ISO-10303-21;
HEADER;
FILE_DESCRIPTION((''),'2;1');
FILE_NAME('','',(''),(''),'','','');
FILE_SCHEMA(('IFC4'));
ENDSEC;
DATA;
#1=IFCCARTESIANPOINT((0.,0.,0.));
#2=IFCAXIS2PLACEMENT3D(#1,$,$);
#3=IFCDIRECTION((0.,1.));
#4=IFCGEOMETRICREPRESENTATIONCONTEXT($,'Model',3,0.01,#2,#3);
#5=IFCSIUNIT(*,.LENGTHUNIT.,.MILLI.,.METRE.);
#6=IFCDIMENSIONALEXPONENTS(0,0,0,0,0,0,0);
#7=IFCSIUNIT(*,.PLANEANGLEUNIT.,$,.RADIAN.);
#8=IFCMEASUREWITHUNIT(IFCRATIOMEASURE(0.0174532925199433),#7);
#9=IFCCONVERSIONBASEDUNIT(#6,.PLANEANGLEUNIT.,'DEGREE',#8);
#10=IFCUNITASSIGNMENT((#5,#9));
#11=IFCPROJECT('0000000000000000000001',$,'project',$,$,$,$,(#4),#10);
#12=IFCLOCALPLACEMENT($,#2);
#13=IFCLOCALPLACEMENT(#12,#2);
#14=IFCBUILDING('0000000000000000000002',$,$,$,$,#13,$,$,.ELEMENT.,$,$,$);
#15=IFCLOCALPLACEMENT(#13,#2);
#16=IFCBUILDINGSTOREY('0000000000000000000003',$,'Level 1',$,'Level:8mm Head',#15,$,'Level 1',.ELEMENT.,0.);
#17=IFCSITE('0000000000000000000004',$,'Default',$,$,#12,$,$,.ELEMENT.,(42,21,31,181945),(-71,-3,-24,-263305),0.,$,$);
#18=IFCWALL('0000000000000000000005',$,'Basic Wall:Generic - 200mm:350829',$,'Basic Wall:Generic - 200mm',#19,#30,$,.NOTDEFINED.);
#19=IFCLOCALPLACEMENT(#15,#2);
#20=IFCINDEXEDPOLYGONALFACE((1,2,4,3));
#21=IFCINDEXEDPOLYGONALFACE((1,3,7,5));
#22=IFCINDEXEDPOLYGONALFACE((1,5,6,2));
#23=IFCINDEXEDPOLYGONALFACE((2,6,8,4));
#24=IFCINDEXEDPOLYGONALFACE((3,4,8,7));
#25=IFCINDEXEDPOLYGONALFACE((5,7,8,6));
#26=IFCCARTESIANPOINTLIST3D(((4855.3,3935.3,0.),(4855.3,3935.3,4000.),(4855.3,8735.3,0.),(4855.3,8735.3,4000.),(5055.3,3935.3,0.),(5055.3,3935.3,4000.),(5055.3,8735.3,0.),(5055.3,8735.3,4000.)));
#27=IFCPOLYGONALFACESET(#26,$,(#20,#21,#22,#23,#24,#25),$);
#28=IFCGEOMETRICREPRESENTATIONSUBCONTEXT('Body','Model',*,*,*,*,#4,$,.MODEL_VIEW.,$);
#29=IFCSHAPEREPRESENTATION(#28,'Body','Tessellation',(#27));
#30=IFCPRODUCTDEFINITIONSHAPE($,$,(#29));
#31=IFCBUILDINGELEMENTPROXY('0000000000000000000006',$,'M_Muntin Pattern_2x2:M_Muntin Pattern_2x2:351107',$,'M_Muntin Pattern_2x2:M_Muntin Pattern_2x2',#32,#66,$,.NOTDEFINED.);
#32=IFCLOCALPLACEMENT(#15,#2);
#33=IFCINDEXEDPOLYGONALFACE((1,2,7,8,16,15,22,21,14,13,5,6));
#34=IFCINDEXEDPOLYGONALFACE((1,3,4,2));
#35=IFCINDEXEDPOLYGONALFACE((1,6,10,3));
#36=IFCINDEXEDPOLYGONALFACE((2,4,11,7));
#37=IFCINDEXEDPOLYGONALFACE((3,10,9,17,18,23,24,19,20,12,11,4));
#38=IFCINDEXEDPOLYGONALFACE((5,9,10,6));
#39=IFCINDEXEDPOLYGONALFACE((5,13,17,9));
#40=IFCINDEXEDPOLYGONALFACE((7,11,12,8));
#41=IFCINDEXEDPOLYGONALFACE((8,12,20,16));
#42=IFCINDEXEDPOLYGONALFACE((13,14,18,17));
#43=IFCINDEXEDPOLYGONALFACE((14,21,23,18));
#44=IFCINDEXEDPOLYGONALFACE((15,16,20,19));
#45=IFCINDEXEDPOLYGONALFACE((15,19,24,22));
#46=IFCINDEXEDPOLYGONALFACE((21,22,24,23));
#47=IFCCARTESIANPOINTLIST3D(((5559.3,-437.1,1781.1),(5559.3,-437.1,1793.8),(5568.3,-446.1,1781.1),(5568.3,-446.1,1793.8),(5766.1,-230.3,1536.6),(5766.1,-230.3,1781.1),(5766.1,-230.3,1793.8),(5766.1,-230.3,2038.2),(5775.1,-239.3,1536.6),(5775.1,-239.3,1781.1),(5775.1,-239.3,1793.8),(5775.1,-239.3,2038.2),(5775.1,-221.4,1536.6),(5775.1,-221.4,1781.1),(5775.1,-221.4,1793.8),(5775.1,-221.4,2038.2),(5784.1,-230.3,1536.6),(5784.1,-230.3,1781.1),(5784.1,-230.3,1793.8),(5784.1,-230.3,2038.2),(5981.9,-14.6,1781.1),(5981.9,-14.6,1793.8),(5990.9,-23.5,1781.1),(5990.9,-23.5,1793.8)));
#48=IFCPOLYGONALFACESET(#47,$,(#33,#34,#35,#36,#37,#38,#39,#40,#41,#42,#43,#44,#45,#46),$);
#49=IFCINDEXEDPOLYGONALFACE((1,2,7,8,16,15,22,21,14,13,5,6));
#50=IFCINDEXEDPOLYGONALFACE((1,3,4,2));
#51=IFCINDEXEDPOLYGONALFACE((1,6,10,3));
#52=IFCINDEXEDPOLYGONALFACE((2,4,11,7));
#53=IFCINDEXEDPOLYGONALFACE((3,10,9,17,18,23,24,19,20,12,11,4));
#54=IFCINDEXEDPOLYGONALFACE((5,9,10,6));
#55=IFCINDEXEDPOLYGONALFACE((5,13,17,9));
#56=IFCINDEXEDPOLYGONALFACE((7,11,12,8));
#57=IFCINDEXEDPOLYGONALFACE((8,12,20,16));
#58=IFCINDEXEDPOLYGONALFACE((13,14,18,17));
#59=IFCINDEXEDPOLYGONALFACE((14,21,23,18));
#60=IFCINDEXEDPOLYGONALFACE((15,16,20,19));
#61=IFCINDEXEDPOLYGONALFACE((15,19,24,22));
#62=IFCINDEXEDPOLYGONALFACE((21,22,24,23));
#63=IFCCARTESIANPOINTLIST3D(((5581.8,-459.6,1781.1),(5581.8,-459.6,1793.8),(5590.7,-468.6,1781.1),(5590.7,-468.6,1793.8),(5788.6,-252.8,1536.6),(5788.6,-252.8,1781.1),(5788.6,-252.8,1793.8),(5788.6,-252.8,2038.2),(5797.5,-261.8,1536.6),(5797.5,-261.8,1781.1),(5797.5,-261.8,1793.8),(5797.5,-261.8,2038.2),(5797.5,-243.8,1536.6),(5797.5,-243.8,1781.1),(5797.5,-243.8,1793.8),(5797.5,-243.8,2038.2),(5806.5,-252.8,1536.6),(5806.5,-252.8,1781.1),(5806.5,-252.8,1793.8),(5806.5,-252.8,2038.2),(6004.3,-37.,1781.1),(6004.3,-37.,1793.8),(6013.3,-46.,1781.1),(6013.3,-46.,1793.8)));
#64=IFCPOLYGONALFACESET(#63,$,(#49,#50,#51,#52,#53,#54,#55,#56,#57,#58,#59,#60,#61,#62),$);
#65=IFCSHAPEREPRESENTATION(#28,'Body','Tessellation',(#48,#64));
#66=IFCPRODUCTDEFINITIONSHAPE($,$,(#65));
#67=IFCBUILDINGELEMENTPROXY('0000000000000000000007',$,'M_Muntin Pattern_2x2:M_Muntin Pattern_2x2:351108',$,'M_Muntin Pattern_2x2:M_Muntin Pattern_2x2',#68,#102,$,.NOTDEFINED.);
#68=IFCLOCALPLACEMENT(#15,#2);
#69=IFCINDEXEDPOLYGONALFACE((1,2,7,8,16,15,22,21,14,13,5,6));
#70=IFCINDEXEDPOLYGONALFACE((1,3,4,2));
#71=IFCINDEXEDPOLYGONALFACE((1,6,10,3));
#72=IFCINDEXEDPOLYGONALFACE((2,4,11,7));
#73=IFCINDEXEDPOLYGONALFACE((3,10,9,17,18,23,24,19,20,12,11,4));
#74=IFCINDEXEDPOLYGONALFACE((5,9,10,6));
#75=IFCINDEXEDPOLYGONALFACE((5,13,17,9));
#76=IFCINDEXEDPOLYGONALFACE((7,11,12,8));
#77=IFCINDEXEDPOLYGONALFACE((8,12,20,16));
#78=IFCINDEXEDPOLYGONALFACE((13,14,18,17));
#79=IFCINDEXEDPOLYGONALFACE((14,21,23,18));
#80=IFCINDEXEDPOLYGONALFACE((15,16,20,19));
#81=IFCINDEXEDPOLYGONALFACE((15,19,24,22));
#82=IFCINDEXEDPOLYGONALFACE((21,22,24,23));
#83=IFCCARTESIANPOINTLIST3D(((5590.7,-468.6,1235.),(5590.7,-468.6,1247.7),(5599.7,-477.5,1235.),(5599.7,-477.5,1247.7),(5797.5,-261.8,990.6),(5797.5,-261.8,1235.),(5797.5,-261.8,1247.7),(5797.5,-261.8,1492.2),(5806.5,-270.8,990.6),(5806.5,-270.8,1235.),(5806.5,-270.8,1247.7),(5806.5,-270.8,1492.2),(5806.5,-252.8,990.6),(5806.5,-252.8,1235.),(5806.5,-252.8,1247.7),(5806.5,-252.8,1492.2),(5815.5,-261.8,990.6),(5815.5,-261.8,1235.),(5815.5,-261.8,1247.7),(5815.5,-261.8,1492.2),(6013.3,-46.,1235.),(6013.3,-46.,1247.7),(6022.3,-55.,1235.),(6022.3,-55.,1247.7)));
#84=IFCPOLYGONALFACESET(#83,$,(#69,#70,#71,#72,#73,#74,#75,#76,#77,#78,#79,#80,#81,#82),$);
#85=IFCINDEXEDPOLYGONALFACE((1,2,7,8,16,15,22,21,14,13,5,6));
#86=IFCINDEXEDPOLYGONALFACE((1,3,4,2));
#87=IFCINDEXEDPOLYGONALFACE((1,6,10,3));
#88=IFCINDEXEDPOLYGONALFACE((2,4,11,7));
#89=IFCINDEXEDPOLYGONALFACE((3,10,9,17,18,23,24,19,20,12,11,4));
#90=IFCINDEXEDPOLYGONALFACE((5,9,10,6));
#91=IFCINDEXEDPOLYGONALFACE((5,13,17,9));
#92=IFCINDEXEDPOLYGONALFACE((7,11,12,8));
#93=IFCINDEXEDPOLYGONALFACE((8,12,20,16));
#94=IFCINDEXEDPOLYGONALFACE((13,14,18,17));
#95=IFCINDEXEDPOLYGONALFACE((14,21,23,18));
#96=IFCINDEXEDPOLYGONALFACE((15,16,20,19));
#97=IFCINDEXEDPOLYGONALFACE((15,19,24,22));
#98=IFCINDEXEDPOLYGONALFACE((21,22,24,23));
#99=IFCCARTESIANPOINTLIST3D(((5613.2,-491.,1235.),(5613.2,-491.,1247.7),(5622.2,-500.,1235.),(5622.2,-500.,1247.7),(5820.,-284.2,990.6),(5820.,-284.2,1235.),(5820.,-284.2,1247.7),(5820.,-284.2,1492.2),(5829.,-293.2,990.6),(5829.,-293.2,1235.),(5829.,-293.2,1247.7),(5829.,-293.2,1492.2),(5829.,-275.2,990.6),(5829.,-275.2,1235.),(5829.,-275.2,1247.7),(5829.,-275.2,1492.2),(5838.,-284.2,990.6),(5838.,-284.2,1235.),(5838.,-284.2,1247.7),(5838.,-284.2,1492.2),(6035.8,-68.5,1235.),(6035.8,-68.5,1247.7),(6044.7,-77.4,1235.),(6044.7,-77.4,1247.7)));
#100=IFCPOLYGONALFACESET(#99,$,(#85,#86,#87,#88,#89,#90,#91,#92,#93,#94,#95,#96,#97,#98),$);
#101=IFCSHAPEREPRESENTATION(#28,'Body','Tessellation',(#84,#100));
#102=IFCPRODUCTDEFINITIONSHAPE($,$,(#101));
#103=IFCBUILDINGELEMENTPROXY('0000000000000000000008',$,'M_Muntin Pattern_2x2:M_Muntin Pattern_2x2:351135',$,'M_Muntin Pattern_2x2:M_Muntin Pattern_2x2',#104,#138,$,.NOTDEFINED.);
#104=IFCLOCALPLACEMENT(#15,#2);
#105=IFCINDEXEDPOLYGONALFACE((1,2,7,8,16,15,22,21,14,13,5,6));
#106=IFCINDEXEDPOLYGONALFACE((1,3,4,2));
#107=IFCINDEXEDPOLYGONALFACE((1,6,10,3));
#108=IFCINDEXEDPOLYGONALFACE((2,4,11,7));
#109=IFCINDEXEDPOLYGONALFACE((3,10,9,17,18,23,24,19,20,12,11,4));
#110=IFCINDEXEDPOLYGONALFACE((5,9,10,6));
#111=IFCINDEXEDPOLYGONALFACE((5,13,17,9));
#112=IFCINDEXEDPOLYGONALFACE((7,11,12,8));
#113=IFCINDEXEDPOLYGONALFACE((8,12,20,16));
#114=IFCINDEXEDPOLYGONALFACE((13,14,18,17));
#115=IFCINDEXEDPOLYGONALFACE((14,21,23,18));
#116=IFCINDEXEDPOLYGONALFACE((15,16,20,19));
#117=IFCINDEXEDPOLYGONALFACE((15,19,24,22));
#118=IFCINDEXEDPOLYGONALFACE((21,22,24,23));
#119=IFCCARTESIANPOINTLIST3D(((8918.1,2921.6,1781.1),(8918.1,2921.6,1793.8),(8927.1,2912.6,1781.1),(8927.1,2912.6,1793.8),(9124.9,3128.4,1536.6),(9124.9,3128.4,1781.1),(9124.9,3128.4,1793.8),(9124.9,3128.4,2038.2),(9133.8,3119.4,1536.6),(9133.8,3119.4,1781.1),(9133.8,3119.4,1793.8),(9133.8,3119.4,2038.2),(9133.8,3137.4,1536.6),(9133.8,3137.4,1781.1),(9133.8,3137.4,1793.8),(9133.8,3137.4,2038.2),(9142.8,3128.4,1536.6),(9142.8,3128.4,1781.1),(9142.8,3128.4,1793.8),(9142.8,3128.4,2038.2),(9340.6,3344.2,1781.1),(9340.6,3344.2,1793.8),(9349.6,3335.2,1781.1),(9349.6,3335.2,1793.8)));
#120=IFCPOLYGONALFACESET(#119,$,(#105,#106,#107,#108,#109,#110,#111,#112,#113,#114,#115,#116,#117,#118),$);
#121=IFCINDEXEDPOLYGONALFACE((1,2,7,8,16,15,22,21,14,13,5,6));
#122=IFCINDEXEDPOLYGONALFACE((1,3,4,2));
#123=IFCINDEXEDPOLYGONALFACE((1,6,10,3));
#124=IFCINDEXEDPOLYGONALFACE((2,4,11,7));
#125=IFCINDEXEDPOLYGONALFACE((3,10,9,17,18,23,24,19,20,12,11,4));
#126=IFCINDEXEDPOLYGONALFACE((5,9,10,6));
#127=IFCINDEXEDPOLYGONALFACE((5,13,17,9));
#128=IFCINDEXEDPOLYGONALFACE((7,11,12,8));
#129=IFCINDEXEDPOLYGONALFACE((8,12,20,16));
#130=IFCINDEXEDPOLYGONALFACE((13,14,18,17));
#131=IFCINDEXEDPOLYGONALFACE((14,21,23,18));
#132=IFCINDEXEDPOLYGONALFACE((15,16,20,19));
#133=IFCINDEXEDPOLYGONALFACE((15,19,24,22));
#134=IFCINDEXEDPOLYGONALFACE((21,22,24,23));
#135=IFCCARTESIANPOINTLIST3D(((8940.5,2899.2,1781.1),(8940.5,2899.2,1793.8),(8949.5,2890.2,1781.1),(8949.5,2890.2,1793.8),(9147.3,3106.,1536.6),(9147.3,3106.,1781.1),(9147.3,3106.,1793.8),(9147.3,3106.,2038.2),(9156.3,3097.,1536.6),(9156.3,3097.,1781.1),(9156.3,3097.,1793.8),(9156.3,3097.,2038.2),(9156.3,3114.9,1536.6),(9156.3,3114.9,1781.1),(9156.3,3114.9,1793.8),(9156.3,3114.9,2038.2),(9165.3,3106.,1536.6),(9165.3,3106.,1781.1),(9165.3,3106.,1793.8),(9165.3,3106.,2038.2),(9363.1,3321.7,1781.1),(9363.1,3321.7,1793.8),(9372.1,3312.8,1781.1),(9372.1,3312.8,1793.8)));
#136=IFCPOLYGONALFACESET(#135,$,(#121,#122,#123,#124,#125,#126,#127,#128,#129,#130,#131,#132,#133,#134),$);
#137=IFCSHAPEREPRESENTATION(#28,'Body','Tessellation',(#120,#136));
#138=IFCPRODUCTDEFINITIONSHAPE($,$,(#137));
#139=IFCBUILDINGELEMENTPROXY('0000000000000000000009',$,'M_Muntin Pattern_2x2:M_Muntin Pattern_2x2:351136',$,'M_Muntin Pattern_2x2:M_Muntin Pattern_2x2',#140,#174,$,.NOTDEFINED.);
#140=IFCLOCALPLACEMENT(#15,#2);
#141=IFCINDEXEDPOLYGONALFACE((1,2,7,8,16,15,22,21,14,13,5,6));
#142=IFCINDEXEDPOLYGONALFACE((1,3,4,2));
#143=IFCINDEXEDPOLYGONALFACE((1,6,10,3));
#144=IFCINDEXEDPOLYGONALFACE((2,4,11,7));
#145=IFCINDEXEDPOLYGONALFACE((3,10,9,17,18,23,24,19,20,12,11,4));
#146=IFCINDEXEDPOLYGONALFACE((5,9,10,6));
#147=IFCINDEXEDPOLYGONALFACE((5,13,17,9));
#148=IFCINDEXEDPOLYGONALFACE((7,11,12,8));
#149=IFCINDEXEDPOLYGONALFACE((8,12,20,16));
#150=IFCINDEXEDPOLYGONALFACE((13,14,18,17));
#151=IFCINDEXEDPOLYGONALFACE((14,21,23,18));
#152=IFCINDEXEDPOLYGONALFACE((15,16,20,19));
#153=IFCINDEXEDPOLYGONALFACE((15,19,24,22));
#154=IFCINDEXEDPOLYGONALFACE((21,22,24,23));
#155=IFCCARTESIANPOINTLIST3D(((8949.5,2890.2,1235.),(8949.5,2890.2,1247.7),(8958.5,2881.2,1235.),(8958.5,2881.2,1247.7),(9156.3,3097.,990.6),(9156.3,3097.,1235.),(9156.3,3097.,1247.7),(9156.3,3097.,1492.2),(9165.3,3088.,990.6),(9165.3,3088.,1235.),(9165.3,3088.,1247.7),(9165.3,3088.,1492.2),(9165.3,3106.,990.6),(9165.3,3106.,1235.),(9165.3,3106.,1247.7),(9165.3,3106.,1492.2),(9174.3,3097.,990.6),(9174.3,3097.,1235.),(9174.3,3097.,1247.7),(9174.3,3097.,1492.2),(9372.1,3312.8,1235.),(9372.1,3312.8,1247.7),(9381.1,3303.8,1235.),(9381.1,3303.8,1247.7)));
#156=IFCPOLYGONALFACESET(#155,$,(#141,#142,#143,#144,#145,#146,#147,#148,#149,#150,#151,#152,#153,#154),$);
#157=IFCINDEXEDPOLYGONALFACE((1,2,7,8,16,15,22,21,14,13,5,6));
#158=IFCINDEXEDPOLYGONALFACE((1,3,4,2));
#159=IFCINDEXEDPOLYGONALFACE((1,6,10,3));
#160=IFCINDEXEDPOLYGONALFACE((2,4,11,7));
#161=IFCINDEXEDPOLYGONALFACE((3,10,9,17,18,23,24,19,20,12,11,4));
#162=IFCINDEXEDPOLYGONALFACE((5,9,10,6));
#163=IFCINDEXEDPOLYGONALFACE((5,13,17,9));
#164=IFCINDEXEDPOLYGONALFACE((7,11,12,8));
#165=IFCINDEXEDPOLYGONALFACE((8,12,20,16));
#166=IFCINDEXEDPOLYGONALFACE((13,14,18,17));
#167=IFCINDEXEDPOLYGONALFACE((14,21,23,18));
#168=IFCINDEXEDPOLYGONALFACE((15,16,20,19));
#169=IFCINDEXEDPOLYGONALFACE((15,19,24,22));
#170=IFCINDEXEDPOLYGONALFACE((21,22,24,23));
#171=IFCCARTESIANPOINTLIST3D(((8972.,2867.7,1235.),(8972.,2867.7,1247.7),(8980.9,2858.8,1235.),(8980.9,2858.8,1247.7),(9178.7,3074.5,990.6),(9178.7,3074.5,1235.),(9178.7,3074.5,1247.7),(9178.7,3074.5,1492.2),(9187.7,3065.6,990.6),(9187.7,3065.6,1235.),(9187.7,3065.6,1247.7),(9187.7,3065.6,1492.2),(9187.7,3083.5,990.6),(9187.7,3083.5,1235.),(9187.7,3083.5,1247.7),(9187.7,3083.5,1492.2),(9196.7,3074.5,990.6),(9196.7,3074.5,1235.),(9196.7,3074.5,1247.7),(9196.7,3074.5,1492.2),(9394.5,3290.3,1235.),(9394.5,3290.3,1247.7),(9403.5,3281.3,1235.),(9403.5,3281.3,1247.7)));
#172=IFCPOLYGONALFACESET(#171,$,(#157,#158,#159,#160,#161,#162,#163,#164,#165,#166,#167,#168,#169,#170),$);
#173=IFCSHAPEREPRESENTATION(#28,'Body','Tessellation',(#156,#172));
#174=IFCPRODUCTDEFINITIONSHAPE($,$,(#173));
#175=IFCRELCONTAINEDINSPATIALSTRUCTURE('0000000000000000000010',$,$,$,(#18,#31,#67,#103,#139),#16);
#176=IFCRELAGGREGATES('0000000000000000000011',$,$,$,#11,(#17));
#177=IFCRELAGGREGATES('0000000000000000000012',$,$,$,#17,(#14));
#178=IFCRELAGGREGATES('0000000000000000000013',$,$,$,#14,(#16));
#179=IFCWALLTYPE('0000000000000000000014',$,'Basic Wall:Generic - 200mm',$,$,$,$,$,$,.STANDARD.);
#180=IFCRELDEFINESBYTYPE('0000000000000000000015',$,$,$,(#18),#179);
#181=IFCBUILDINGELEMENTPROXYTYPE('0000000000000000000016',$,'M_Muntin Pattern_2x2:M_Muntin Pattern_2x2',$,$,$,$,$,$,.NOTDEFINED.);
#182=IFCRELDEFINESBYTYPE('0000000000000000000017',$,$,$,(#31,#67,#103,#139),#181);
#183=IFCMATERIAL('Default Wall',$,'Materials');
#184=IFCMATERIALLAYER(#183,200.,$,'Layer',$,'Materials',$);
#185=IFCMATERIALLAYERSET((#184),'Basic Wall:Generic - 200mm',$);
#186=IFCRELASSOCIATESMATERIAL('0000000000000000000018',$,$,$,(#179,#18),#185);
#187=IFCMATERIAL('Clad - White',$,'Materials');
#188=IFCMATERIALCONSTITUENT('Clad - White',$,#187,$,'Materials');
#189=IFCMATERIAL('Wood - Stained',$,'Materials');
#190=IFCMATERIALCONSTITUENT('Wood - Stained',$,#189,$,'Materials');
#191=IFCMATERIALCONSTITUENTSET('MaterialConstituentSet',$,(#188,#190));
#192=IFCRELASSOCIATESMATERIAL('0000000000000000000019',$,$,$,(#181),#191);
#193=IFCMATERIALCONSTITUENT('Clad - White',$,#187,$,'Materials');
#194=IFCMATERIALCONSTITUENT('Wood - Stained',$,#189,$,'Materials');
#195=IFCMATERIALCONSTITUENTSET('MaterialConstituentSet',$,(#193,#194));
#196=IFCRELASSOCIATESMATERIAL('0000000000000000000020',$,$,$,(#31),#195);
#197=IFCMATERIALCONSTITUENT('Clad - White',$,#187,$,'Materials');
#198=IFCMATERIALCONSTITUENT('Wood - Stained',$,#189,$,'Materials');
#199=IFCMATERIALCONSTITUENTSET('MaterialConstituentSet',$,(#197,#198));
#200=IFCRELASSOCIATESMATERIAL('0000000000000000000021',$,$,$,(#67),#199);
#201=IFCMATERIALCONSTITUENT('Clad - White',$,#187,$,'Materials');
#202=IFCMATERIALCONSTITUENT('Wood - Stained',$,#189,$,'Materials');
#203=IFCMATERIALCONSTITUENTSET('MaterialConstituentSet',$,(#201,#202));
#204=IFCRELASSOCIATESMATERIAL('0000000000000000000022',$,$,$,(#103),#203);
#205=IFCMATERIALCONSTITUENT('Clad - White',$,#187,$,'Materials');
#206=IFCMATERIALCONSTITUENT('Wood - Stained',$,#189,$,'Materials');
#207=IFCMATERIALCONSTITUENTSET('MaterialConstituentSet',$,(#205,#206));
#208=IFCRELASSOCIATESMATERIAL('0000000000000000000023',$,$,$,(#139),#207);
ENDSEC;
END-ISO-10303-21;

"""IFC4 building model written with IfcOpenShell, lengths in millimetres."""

from ifc_helpers import new_model, entity, si_unit, converted_unit, direction, frame, frame_2d, origin, place, context, subcontext, project, spatial, polyline, rectangle, outline, extrude, source, transform, mapped, material, layer, layer_set, layer_usage, constituent, constituent_set, type_object, type_shapes, element, save


model = new_model("IFC4")

# Units and contexts
model_context = context("Model", 3, precision=0.01, world=origin(), true_north=direction((0.0, 1.0)))
body_context = subcontext(model_context, "Body", "Model", "MODEL_VIEW")
ifc_project = project(units=[si_unit("LENGTHUNIT", "METRE", prefix="MILLI"), converted_unit("PLANEANGLEUNIT", "DEGREE", entity("IfcRatioMeasure", 0.0174532925199433), si_unit("PLANEANGLEUNIT", "RADIAN"), dimensions=[0, 0, 0, 0, 0, 0, 0])], contexts=[model_context])

# Site, building, storey
site_placement = place(None, origin())
site = spatial("IfcSite", under=ifc_project, at=site_placement, Name="Default", CompositionType="ELEMENT", RefLatitude=(42, 21, 31, 181945), RefLongitude=(-71, -3, -24, -263305), RefElevation=0.0)
building_placement = place(site_placement, origin())
building = spatial("IfcBuilding", under=site, at=building_placement, CompositionType="ELEMENT")
storey_placement = place(building_placement, origin())
storey = spatial("IfcBuildingStorey", under=building, at=storey_placement, Name="Level 1", ObjectType="Level:8mm Head", LongName="Level 1", CompositionType="ELEMENT", Elevation=0.0)

# Shared definitions
ifc_material_1 = material(Name="Default Wall", Category="Materials")
ifc_layer = layer(ifc_material_1, 200.0, Name="Layer", Category="Materials")
ifc_layer_set = layer_set([ifc_layer], Name="Basic Wall:Generic - 200mm")
wall_type = type_object("IfcWallType", Name="Basic Wall:Generic - 200mm", PredefinedType="STANDARD", material=ifc_layer_set)
ifc_material_2 = material(Name="Wood - Stained", Category="Materials")

# Wall
ifc_layer_usage_1 = layer_usage(ifc_layer_set, "AXIS2", "NEGATIVE", 100.0)
wall_1_placement = place(storey_placement, frame((4955.3, 3935.3, 0.0), z_axis=(0.0, 0.0, 1.0), x_axis=(0.0, 1.0, 0.0)))
element("IfcWall", 1, at=wall_1_placement, inside=storey, type_object=wall_type, material=ifc_layer_usage_1, Name="Basic Wall:Generic - 200mm:350829", ObjectType="Basic Wall:Generic - 200mm", PredefinedType="NOTDEFINED", context=body_context, shape_type="SweptSolid", body=[
    extrude(rectangle(XDim=4800.0, YDim=200.0, at=frame_2d((2400.0, 0.0), x_axis=(-1.0, 0.0))), origin(), (0.0, 0.0, 1.0), 4000.0),
])

# Building element proxies
ifc_material_3 = material(Name="Clad - White", Category="Materials")
ifc_constituent_1 = constituent(ifc_material_3, Name="Clad - White", Category="Materials")
ifc_constituent_2 = constituent(ifc_material_2, Name="Wood - Stained", Category="Materials")
ifc_constituent_set_1 = constituent_set(constituents=[ifc_constituent_1, ifc_constituent_2], Name="MaterialConstituentSet")
ifc_constituent_3 = constituent(ifc_material_3, Name="Clad - White", Category="Materials")
ifc_constituent_4 = constituent(ifc_material_2, Name="Wood - Stained", Category="Materials")
ifc_constituent_set_2 = constituent_set(constituents=[ifc_constituent_3, ifc_constituent_4], Name="MaterialConstituentSet")
building_element_proxy_type_1 = type_object("IfcBuildingElementProxyType", Name="M_Muntin Pattern_2x2:M_Muntin Pattern_2x2", PredefinedType="NOTDEFINED", material=ifc_constituent_set_2)
shared_shape_1 = source(origin(), body_context, "Body", "SweptSolid", [
    extrude(outline(polyline([(6.4, -6.4), (250.8, -6.4), (250.8, 6.3), (6.4, 6.3), (6.4, 298.8), (-6.3, 298.8), (-6.3, 6.3), (-250.8, 6.3), (-250.8, -6.4), (-6.3, -6.4), (-6.3, -298.8), (6.4, -298.8), (6.4, -6.4)])), frame((0.0, 9.5, 250.8), z_axis=(0.0, 1.0, 0.0), x_axis=(0.0, 0.0, 1.0)), (0.0, 0.0, 1.0), 12.7),
    extrude(outline(polyline([(6.4, -6.4), (250.8, -6.4), (250.8, 6.3), (6.4, 6.3), (6.4, 298.8), (-6.3, 298.8), (-6.3, 6.3), (-250.8, 6.3), (-250.8, -6.4), (-6.3, -6.4), (-6.3, -298.8), (6.4, -298.8), (6.4, -6.4)])), frame((0.0, -22.2, 250.8), z_axis=(0.0, 1.0, 0.0), x_axis=(0.0, 0.0, 1.0)), (0.0, 0.0, 1.0), 12.7),
])
type_shapes(building_element_proxy_type_1, [shared_shape_1])
proxy_1_placement = place(storey_placement, frame((5786.3, -241.6, 1536.6), z_axis=(0.0, 0.0, 1.0), x_axis=(0.707107, 0.707107, 0.0)))
element("IfcBuildingElementProxy", 2, at=proxy_1_placement, inside=storey, type_object=building_element_proxy_type_1, material=ifc_constituent_set_1, Name="M_Muntin Pattern_2x2:M_Muntin Pattern_2x2:351107", ObjectType="M_Muntin Pattern_2x2:M_Muntin Pattern_2x2", PredefinedType="NOTDEFINED", context=body_context, shape_type="MappedRepresentation", body=[
    mapped(shared_shape_1, transform((0.0, 0.0, 0.0), scale=1.0)),
])
ifc_constituent_5 = constituent(ifc_material_3, Name="Clad - White", Category="Materials")
ifc_constituent_6 = constituent(ifc_material_2, Name="Wood - Stained", Category="Materials")
ifc_constituent_set_3 = constituent_set(constituents=[ifc_constituent_5, ifc_constituent_6], Name="MaterialConstituentSet")
proxy_2_placement = place(storey_placement, frame((5817.7, -273.0, 990.6), z_axis=(0.0, 0.0, 1.0), x_axis=(0.707107, 0.707107, 0.0)))
element("IfcBuildingElementProxy", 3, at=proxy_2_placement, inside=storey, type_object=building_element_proxy_type_1, material=ifc_constituent_set_3, Name="M_Muntin Pattern_2x2:M_Muntin Pattern_2x2:351108", ObjectType="M_Muntin Pattern_2x2:M_Muntin Pattern_2x2", PredefinedType="NOTDEFINED", context=body_context, shape_type="MappedRepresentation", body=[
    mapped(shared_shape_1, transform((0.0, 0.0, 0.0), scale=1.0)),
])
ifc_constituent_7 = constituent(ifc_material_3, Name="Clad - White", Category="Materials")
ifc_constituent_8 = constituent(ifc_material_2, Name="Wood - Stained", Category="Materials")
ifc_constituent_set_4 = constituent_set(constituents=[ifc_constituent_7, ifc_constituent_8], Name="MaterialConstituentSet")
proxy_3_placement = place(storey_placement, frame((9145.1, 3117.2, 1536.6), z_axis=(0.0, 0.0, 1.0), x_axis=(0.707107, 0.707107, 0.0)))
element("IfcBuildingElementProxy", 4, at=proxy_3_placement, inside=storey, type_object=building_element_proxy_type_1, material=ifc_constituent_set_4, Name="M_Muntin Pattern_2x2:M_Muntin Pattern_2x2:351135", ObjectType="M_Muntin Pattern_2x2:M_Muntin Pattern_2x2", PredefinedType="NOTDEFINED", context=body_context, shape_type="MappedRepresentation", body=[
    mapped(shared_shape_1, transform((0.0, 0.0, 0.0), scale=1.0)),
])
ifc_constituent_9 = constituent(ifc_material_3, Name="Clad - White", Category="Materials")
ifc_constituent_10 = constituent(ifc_material_2, Name="Wood - Stained", Category="Materials")
ifc_constituent_set_5 = constituent_set(constituents=[ifc_constituent_9, ifc_constituent_10], Name="MaterialConstituentSet")
proxy_4_placement = place(storey_placement, frame((9176.5, 3085.8, 990.6), z_axis=(0.0, 0.0, 1.0), x_axis=(0.707107, 0.707107, 0.0)))
element("IfcBuildingElementProxy", 5, at=proxy_4_placement, inside=storey, type_object=building_element_proxy_type_1, material=ifc_constituent_set_5, Name="M_Muntin Pattern_2x2:M_Muntin Pattern_2x2:351136", ObjectType="M_Muntin Pattern_2x2:M_Muntin Pattern_2x2", PredefinedType="NOTDEFINED", context=body_context, shape_type="MappedRepresentation", body=[
    mapped(shared_shape_1, transform((0.0, 0.0, 0.0), scale=1.0)),
])

save(model, "model.ifc")
